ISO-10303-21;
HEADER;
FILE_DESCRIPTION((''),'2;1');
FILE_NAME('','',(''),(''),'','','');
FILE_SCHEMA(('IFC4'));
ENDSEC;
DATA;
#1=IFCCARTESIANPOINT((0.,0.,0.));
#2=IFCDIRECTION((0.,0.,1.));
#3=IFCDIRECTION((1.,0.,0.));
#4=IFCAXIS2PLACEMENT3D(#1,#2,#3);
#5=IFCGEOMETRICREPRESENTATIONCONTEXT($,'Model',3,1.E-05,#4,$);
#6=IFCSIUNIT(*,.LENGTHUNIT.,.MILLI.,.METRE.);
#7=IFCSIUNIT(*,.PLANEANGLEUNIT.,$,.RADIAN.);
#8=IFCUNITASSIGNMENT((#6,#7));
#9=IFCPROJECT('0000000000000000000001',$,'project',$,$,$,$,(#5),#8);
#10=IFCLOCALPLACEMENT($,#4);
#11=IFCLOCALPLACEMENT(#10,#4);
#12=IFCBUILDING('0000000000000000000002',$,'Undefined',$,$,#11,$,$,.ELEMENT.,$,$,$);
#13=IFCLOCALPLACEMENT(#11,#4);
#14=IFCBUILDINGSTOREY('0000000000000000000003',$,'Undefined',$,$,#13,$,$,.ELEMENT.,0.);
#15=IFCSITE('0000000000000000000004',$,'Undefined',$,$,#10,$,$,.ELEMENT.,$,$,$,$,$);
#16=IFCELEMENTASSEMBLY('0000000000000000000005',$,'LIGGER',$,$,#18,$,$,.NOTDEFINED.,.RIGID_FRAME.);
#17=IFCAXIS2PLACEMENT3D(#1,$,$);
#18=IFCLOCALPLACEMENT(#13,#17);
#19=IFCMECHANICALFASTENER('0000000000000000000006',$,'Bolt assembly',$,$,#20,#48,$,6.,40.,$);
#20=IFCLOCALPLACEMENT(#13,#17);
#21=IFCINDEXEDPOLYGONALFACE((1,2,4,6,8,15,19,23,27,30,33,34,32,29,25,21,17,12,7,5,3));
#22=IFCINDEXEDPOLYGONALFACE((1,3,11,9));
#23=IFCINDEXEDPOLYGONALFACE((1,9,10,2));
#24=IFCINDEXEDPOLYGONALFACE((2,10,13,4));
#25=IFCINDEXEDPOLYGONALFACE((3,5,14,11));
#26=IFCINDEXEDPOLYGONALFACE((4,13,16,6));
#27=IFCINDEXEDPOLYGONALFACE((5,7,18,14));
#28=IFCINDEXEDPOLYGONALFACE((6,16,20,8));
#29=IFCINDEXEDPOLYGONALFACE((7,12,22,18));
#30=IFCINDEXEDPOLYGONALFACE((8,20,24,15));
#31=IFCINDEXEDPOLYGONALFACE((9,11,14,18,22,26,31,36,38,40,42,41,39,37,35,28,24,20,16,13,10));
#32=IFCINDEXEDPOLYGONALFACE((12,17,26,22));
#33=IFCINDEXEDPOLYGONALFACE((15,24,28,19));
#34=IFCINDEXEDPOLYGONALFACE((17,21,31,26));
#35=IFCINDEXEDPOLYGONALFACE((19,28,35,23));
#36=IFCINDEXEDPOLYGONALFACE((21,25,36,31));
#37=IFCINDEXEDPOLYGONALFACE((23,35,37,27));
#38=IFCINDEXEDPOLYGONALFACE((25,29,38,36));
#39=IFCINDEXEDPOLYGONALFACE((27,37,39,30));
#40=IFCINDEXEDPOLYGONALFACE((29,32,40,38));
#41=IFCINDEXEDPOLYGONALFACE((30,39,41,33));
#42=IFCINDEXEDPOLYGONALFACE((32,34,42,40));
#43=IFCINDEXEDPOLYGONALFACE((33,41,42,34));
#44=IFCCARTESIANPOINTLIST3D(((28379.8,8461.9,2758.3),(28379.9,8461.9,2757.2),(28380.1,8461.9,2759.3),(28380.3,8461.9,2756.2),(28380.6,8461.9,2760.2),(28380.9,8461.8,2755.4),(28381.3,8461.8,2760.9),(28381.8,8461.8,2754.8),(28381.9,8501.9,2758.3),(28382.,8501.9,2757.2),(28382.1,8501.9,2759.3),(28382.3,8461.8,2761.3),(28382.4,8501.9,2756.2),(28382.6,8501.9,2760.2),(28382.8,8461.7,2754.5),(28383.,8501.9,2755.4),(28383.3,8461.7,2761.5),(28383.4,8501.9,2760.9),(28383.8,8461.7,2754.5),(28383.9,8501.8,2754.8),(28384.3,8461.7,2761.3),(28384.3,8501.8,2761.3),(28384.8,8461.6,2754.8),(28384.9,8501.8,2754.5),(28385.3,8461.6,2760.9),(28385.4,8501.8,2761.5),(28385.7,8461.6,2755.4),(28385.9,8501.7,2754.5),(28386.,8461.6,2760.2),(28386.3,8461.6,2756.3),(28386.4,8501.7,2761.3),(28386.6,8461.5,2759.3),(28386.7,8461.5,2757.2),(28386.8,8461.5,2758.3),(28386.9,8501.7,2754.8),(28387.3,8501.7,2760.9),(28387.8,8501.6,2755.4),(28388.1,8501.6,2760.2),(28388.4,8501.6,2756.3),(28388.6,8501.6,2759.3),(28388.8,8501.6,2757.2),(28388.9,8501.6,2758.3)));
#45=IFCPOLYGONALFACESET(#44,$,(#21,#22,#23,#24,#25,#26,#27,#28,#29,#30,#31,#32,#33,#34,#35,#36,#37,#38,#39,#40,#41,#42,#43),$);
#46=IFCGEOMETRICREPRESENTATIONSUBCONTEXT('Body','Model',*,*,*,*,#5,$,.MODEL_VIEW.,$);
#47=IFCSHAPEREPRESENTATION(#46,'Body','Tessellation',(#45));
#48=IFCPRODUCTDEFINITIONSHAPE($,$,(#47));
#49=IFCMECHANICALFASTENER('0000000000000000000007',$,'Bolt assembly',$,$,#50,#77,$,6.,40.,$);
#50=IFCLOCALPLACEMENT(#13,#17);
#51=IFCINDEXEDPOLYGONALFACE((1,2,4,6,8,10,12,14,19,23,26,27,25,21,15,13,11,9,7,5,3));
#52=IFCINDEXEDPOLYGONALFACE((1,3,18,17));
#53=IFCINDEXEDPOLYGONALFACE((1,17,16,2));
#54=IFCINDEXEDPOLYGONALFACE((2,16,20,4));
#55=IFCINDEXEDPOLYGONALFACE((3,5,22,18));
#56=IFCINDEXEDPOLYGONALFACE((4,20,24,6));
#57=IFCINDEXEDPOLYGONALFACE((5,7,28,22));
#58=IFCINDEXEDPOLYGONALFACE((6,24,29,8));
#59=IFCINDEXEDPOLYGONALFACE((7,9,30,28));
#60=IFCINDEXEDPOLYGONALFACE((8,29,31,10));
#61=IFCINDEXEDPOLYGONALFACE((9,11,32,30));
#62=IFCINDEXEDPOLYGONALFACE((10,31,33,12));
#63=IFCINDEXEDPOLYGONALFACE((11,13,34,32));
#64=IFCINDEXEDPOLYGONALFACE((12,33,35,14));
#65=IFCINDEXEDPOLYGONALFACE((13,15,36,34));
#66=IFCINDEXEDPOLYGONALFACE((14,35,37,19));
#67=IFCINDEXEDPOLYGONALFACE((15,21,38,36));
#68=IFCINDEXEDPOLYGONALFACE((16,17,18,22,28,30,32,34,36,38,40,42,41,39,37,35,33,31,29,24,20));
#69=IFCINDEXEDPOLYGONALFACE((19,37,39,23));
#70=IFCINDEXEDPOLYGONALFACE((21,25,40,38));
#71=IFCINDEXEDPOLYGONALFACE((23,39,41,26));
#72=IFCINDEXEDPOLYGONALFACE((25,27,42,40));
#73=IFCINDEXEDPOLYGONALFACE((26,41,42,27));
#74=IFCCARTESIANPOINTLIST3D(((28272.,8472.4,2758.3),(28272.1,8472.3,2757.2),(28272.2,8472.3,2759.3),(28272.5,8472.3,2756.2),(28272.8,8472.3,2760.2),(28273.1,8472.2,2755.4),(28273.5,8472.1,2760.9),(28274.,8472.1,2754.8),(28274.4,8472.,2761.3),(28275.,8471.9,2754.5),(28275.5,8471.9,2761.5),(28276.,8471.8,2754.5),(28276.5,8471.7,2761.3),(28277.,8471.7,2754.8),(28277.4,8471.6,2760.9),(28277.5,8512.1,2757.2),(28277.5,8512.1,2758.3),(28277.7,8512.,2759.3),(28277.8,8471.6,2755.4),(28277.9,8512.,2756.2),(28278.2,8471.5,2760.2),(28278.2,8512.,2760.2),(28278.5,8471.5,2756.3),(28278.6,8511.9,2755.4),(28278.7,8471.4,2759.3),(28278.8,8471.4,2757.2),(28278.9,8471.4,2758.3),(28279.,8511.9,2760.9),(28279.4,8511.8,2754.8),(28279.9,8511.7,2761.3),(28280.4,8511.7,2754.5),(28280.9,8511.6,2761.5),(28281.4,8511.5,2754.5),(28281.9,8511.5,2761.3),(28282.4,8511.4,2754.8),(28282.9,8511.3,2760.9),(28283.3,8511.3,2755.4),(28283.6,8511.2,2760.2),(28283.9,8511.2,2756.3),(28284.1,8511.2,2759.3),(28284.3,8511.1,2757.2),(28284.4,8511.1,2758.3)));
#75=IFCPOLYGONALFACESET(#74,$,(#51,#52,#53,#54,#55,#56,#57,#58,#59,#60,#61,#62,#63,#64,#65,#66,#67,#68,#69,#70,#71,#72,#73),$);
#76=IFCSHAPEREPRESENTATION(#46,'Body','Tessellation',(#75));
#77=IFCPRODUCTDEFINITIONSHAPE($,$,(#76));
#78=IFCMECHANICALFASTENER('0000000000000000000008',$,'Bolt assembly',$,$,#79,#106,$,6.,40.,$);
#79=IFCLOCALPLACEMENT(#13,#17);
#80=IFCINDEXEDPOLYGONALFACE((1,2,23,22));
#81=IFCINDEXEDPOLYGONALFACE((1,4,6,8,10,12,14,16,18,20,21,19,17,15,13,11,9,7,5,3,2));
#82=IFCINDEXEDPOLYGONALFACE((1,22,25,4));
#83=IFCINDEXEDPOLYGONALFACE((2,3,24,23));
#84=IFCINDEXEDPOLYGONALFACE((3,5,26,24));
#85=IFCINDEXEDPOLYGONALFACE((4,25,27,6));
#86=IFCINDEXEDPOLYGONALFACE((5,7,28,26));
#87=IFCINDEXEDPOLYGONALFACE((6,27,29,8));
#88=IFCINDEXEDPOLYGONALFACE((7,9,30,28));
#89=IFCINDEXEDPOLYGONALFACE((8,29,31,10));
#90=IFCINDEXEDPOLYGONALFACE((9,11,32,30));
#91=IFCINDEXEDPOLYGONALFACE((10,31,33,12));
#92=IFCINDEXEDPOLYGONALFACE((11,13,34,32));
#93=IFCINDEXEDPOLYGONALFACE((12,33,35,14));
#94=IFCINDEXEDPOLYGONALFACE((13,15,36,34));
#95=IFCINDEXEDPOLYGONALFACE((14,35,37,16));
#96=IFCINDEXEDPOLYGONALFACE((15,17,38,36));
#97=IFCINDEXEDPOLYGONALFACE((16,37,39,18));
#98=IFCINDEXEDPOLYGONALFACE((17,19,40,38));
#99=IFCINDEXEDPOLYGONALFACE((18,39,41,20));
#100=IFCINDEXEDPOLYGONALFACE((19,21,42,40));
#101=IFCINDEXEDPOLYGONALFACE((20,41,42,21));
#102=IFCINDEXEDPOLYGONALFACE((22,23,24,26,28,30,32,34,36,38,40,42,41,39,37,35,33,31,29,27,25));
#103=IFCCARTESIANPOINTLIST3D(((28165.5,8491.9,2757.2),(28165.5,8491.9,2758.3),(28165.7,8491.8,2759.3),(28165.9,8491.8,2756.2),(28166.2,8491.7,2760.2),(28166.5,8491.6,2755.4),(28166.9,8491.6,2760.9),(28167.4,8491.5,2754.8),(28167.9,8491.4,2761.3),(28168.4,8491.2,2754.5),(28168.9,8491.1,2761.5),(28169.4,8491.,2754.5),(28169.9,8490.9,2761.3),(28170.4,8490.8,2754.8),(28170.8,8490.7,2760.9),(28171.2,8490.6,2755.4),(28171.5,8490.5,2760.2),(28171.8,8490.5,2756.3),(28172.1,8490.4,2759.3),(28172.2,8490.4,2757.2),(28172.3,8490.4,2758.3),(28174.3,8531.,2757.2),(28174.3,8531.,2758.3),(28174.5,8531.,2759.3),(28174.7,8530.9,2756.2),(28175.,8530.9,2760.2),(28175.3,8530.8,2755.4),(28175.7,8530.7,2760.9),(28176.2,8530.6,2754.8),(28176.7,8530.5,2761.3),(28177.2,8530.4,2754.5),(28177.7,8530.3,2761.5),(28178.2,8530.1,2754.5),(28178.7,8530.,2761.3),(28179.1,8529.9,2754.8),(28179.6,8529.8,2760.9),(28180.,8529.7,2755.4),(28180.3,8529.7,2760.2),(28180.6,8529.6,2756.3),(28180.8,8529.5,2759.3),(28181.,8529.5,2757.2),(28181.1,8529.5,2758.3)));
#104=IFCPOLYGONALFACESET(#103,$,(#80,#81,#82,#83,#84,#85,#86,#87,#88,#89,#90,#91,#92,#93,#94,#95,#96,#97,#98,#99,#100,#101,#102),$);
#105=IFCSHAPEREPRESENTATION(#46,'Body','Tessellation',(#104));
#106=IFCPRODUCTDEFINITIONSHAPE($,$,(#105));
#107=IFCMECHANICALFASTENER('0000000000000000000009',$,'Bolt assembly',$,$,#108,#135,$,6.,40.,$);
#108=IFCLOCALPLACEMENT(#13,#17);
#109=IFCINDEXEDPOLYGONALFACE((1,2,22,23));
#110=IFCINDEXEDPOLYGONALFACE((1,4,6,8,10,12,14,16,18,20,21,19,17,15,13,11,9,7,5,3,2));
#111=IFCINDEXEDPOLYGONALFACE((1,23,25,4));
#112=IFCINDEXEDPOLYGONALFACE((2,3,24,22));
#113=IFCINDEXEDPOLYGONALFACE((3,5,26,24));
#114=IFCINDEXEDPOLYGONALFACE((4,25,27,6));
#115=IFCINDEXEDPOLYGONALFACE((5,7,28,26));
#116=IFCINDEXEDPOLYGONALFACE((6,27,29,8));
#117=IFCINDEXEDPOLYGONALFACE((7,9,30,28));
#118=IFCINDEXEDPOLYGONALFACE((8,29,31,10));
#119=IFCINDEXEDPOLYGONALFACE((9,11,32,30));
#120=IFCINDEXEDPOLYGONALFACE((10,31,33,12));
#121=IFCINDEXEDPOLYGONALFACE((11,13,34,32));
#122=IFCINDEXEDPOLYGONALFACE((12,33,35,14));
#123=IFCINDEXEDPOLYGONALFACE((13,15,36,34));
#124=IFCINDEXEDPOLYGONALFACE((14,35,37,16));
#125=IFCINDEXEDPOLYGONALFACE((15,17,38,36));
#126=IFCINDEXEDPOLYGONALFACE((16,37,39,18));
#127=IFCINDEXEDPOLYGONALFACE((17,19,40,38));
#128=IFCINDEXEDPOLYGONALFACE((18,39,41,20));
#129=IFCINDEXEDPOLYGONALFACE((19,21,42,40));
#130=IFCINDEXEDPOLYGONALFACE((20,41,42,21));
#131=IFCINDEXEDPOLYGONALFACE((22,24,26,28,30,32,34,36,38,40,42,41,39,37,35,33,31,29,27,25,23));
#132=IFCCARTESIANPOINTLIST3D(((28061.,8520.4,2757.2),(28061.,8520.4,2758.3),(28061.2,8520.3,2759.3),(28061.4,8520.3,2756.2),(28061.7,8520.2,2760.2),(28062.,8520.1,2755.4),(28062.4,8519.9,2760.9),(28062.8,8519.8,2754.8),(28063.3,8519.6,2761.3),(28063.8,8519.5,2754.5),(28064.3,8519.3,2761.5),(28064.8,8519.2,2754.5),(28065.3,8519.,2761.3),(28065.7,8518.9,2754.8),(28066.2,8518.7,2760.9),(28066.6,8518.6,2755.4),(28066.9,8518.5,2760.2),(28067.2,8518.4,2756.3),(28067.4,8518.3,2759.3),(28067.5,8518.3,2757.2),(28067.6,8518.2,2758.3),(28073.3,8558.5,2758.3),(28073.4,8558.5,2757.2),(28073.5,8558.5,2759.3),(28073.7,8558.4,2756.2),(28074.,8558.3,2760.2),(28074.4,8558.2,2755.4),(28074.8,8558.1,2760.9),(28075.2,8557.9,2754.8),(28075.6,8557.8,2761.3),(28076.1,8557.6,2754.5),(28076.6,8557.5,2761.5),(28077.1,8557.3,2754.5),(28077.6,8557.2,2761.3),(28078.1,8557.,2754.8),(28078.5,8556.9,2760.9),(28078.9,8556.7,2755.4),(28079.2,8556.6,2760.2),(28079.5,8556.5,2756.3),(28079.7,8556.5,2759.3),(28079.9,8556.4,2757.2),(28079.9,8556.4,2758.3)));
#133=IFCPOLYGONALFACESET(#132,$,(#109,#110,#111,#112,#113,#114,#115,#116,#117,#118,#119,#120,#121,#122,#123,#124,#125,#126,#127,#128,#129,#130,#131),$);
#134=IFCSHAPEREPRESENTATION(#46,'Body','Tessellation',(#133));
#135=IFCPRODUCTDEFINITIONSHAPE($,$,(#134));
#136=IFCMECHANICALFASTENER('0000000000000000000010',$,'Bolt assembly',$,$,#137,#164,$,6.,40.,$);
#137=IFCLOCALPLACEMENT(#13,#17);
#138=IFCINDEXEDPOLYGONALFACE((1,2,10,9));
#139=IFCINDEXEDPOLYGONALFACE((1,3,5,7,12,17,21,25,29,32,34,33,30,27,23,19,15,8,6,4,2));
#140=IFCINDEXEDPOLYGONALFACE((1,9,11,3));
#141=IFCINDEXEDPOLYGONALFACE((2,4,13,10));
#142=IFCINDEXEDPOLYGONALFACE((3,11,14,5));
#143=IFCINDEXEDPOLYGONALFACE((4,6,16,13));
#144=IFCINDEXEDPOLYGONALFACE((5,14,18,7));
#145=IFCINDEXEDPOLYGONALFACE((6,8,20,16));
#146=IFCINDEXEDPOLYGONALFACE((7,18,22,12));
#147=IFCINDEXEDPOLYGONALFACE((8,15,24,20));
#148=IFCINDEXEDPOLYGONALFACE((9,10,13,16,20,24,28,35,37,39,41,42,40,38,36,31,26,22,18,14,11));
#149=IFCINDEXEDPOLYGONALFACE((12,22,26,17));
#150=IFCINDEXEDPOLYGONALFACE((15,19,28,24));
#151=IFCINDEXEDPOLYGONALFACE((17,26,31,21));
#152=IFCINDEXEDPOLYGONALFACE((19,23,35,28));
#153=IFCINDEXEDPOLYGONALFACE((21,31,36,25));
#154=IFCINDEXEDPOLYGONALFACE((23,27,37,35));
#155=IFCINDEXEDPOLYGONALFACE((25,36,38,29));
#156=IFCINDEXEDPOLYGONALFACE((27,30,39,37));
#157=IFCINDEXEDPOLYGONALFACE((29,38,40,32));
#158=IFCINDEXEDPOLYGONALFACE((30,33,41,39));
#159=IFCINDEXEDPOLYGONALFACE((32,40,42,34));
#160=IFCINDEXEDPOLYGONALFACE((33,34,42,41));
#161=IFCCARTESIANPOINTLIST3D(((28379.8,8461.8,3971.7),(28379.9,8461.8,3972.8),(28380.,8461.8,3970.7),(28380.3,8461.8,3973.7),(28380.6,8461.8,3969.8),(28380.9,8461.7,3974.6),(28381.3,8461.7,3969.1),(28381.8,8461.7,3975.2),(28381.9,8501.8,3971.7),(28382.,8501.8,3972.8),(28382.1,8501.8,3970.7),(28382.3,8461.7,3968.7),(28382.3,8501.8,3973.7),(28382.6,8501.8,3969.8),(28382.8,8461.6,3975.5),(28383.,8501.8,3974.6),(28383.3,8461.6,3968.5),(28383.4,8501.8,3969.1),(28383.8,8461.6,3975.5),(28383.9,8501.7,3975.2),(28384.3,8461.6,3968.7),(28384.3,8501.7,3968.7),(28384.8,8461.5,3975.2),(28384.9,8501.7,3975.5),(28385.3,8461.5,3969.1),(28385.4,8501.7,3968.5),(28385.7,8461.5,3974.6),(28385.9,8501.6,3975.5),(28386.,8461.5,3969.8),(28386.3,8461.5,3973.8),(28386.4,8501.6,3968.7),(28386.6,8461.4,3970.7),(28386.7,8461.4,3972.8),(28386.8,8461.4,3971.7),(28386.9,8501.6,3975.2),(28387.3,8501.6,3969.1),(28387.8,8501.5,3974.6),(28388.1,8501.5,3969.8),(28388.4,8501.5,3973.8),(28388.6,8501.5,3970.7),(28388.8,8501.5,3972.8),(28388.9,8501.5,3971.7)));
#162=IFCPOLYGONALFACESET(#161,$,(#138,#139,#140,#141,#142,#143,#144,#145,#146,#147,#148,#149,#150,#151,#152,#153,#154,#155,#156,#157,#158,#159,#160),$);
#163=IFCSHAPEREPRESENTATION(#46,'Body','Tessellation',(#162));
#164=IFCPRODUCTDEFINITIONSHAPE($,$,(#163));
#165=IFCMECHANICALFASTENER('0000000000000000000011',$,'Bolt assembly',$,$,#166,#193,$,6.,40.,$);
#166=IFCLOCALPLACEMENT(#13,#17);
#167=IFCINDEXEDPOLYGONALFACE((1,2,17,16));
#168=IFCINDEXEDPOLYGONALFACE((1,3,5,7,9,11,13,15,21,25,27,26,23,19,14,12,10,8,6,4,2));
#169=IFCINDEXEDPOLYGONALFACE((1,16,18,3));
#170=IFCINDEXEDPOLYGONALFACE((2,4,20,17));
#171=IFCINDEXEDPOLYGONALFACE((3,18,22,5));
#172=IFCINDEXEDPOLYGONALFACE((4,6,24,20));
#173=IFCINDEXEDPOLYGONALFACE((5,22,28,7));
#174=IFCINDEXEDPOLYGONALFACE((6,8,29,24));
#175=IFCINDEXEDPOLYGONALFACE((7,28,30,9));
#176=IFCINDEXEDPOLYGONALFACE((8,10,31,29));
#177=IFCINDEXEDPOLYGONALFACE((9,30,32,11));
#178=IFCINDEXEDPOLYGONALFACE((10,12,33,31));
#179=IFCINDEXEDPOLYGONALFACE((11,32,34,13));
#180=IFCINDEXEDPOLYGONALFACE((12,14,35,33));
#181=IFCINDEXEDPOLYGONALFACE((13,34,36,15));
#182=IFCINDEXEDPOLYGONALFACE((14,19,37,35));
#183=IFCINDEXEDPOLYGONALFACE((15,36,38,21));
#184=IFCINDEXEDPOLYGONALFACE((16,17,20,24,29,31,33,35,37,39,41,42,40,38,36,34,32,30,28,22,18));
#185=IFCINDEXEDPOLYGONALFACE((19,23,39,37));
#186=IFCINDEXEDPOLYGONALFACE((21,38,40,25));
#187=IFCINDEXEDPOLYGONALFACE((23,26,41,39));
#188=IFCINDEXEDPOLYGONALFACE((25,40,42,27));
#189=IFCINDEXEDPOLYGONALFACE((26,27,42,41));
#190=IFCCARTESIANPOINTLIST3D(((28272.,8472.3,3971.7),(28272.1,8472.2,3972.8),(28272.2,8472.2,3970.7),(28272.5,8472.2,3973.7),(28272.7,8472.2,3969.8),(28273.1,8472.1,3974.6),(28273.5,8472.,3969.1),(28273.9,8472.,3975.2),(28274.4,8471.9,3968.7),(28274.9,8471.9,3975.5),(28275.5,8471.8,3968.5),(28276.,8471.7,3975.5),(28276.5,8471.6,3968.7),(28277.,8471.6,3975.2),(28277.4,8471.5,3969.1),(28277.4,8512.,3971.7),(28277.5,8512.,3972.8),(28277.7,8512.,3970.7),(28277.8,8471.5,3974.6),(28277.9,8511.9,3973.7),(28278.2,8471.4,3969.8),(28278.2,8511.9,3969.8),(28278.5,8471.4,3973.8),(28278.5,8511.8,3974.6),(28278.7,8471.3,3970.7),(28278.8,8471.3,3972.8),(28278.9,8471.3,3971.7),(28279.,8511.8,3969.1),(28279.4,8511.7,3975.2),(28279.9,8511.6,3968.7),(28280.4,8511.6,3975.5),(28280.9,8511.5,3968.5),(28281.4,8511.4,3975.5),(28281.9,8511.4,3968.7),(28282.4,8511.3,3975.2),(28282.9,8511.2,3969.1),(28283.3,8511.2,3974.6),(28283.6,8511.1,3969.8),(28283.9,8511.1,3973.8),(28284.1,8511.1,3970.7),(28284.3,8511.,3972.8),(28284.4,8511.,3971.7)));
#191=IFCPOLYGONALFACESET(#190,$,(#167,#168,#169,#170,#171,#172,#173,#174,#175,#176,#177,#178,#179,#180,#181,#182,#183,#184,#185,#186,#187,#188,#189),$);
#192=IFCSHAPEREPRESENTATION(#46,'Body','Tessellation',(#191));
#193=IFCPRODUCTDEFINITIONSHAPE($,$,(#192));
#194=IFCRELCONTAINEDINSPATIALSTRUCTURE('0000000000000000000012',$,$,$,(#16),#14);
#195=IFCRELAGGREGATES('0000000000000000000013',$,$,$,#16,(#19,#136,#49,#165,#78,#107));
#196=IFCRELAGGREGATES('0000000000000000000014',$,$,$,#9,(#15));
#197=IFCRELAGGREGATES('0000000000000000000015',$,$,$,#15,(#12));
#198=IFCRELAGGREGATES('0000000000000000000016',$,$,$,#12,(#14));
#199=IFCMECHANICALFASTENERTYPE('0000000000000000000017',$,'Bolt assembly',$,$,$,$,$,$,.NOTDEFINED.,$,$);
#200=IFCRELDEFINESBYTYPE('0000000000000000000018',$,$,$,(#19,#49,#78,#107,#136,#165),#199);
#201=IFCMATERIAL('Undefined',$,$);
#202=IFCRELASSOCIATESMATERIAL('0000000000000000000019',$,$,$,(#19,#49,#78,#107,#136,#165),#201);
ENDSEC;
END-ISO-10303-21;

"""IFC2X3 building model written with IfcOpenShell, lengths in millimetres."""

from ifc_helpers import new_model, si_unit, frame, origin_with_axes, origin_2d_with_axis, place, context, subcontext, project, spatial, circle, extrude, source, transform, mapped, material, type_object, element, aggregate, save


model = new_model("IFC2X3")

# Units and contexts
model_context = context("Model", 3, precision=1e-05, world=origin_with_axes())
body_context = subcontext(model_context, "Body", "Model", "MODEL_VIEW")
ifc_project = project(units=[si_unit("LENGTHUNIT", "METRE", prefix="MILLI"), si_unit("PLANEANGLEUNIT", "RADIAN")], contexts=[model_context])

# Site, building, storey
site_placement = place(None, origin_with_axes())
site = spatial("IfcSite", under=ifc_project, at=site_placement, Name="Undefined", CompositionType="ELEMENT")
building_placement = place(site_placement, origin_with_axes())
building = spatial("IfcBuilding", under=site, at=building_placement, Name="Undefined", CompositionType="ELEMENT")
storey_placement = place(building_placement, origin_with_axes())
storey = spatial("IfcBuildingStorey", under=building, at=storey_placement, Name="Undefined", CompositionType="ELEMENT", Elevation=0.0)

# Element assembly
assembly_1_placement = place(storey_placement, origin_with_axes())
assembly_1 = element("IfcElementAssembly", 1, at=assembly_1_placement, inside=storey, Name="LIGGER", AssemblyPlace="NOTDEFINED", PredefinedType="RIGID_FRAME")

# Mechanical fasteners
ifc_material_1 = material(Name="Undefined")
mechanical_fastener_type = type_object("IfcMechanicalFastenerType", Name="Bolt assembly")
shared_shape_1 = source(origin_with_axes(), body_context, "Body", "SweptSolid", [
    extrude(circle(Radius=3.5, at=origin_2d_with_axis()), frame((0.0, 0.0, 0.0), z_axis=(0.0, 1.0, 0.0), x_axis=(1.0, 0.0, 0.0)), (0.0, 0.0, 1.0), 40.1),
])
mechanical_fastener_1_placement = place(assembly_1_placement, frame((28383.3, 8461.7, 2758.0), z_axis=(-0.998665, 0.051664, 0.0), x_axis=(0.0, 0.0, 1.0)))
mechanical_fastener_1 = element("IfcMechanicalFastener", 2, at=mechanical_fastener_1_placement, type_object=mechanical_fastener_type, material=ifc_material_1, Name="Bolt assembly", NominalDiameter=6.0, NominalLength=40.0, context=body_context, shape_type="MappedRepresentation", body=[
    mapped(shared_shape_1, transform((0.0, 0.0, 0.0))),
])
mechanical_fastener_2_placement = place(assembly_1_placement, frame((28275.5, 8471.9, 2758.0), z_axis=(-0.990721, 0.135913, 0.0), x_axis=(0.0, 0.0, 1.0)))
mechanical_fastener_2 = element("IfcMechanicalFastener", 3, at=mechanical_fastener_2_placement, type_object=mechanical_fastener_type, material=ifc_material_1, Name="Bolt assembly", NominalDiameter=6.0, NominalLength=40.0, context=body_context, shape_type="MappedRepresentation", body=[
    mapped(shared_shape_1, transform((0.0, 0.0, 0.0))),
])
mechanical_fastener_3_placement = place(assembly_1_placement, frame((28168.9, 8491.1, 2758.0), z_axis=(-0.975682, 0.21919, 0.0), x_axis=(0.0, 0.0, 1.0)))
mechanical_fastener_3 = element("IfcMechanicalFastener", 4, at=mechanical_fastener_3_placement, type_object=mechanical_fastener_type, material=ifc_material_1, Name="Bolt assembly", NominalDiameter=6.0, NominalLength=40.0, context=body_context, shape_type="MappedRepresentation", body=[
    mapped(shared_shape_1, transform((0.0, 0.0, 0.0))),
])
mechanical_fastener_4_placement = place(assembly_1_placement, frame((28064.3, 8519.3, 2758.0), z_axis=(-0.951464, 0.307761, 0.0), x_axis=(0.0, 0.0, 1.0)))
mechanical_fastener_4 = element("IfcMechanicalFastener", 5, at=mechanical_fastener_4_placement, type_object=mechanical_fastener_type, material=ifc_material_1, Name="Bolt assembly", NominalDiameter=6.0, NominalLength=40.0, context=body_context, shape_type="MappedRepresentation", body=[
    mapped(shared_shape_1, transform((0.0, 0.0, 0.0))),
])
shared_shape_2 = source(origin_with_axes(), body_context, "Body", "SweptSolid", [
    extrude(circle(Radius=3.5, at=origin_2d_with_axis()), frame((0.0, -40.0, 0.0), z_axis=(0.0, 1.0, 0.0), x_axis=(1.0, 0.0, 0.0)), (0.0, 0.0, 1.0), 40.1),
])
mechanical_fastener_5_placement = place(assembly_1_placement, frame((28383.3, 8461.7, 3972.0), z_axis=(-0.998665, 0.051664, 0.0), x_axis=(0.0, 0.0, -1.0)))
mechanical_fastener_5 = element("IfcMechanicalFastener", 6, at=mechanical_fastener_5_placement, type_object=mechanical_fastener_type, material=ifc_material_1, Name="Bolt assembly", NominalDiameter=6.0, NominalLength=40.0, context=body_context, shape_type="MappedRepresentation", body=[
    mapped(shared_shape_2, transform((0.0, 0.0, 0.0))),
])
mechanical_fastener_6_placement = place(assembly_1_placement, frame((28275.5, 8471.9, 3972.0), z_axis=(-0.990721, 0.135913, 0.0), x_axis=(0.0, 0.0, -1.0)))
mechanical_fastener_6 = element("IfcMechanicalFastener", 7, at=mechanical_fastener_6_placement, type_object=mechanical_fastener_type, material=ifc_material_1, Name="Bolt assembly", NominalDiameter=6.0, NominalLength=40.0, context=body_context, shape_type="MappedRepresentation", body=[
    mapped(shared_shape_2, transform((0.0, 0.0, 0.0))),
])
aggregate(assembly_1, [mechanical_fastener_1, mechanical_fastener_5, mechanical_fastener_2, mechanical_fastener_6, mechanical_fastener_3, mechanical_fastener_4])

save(model, "model.ifc")
